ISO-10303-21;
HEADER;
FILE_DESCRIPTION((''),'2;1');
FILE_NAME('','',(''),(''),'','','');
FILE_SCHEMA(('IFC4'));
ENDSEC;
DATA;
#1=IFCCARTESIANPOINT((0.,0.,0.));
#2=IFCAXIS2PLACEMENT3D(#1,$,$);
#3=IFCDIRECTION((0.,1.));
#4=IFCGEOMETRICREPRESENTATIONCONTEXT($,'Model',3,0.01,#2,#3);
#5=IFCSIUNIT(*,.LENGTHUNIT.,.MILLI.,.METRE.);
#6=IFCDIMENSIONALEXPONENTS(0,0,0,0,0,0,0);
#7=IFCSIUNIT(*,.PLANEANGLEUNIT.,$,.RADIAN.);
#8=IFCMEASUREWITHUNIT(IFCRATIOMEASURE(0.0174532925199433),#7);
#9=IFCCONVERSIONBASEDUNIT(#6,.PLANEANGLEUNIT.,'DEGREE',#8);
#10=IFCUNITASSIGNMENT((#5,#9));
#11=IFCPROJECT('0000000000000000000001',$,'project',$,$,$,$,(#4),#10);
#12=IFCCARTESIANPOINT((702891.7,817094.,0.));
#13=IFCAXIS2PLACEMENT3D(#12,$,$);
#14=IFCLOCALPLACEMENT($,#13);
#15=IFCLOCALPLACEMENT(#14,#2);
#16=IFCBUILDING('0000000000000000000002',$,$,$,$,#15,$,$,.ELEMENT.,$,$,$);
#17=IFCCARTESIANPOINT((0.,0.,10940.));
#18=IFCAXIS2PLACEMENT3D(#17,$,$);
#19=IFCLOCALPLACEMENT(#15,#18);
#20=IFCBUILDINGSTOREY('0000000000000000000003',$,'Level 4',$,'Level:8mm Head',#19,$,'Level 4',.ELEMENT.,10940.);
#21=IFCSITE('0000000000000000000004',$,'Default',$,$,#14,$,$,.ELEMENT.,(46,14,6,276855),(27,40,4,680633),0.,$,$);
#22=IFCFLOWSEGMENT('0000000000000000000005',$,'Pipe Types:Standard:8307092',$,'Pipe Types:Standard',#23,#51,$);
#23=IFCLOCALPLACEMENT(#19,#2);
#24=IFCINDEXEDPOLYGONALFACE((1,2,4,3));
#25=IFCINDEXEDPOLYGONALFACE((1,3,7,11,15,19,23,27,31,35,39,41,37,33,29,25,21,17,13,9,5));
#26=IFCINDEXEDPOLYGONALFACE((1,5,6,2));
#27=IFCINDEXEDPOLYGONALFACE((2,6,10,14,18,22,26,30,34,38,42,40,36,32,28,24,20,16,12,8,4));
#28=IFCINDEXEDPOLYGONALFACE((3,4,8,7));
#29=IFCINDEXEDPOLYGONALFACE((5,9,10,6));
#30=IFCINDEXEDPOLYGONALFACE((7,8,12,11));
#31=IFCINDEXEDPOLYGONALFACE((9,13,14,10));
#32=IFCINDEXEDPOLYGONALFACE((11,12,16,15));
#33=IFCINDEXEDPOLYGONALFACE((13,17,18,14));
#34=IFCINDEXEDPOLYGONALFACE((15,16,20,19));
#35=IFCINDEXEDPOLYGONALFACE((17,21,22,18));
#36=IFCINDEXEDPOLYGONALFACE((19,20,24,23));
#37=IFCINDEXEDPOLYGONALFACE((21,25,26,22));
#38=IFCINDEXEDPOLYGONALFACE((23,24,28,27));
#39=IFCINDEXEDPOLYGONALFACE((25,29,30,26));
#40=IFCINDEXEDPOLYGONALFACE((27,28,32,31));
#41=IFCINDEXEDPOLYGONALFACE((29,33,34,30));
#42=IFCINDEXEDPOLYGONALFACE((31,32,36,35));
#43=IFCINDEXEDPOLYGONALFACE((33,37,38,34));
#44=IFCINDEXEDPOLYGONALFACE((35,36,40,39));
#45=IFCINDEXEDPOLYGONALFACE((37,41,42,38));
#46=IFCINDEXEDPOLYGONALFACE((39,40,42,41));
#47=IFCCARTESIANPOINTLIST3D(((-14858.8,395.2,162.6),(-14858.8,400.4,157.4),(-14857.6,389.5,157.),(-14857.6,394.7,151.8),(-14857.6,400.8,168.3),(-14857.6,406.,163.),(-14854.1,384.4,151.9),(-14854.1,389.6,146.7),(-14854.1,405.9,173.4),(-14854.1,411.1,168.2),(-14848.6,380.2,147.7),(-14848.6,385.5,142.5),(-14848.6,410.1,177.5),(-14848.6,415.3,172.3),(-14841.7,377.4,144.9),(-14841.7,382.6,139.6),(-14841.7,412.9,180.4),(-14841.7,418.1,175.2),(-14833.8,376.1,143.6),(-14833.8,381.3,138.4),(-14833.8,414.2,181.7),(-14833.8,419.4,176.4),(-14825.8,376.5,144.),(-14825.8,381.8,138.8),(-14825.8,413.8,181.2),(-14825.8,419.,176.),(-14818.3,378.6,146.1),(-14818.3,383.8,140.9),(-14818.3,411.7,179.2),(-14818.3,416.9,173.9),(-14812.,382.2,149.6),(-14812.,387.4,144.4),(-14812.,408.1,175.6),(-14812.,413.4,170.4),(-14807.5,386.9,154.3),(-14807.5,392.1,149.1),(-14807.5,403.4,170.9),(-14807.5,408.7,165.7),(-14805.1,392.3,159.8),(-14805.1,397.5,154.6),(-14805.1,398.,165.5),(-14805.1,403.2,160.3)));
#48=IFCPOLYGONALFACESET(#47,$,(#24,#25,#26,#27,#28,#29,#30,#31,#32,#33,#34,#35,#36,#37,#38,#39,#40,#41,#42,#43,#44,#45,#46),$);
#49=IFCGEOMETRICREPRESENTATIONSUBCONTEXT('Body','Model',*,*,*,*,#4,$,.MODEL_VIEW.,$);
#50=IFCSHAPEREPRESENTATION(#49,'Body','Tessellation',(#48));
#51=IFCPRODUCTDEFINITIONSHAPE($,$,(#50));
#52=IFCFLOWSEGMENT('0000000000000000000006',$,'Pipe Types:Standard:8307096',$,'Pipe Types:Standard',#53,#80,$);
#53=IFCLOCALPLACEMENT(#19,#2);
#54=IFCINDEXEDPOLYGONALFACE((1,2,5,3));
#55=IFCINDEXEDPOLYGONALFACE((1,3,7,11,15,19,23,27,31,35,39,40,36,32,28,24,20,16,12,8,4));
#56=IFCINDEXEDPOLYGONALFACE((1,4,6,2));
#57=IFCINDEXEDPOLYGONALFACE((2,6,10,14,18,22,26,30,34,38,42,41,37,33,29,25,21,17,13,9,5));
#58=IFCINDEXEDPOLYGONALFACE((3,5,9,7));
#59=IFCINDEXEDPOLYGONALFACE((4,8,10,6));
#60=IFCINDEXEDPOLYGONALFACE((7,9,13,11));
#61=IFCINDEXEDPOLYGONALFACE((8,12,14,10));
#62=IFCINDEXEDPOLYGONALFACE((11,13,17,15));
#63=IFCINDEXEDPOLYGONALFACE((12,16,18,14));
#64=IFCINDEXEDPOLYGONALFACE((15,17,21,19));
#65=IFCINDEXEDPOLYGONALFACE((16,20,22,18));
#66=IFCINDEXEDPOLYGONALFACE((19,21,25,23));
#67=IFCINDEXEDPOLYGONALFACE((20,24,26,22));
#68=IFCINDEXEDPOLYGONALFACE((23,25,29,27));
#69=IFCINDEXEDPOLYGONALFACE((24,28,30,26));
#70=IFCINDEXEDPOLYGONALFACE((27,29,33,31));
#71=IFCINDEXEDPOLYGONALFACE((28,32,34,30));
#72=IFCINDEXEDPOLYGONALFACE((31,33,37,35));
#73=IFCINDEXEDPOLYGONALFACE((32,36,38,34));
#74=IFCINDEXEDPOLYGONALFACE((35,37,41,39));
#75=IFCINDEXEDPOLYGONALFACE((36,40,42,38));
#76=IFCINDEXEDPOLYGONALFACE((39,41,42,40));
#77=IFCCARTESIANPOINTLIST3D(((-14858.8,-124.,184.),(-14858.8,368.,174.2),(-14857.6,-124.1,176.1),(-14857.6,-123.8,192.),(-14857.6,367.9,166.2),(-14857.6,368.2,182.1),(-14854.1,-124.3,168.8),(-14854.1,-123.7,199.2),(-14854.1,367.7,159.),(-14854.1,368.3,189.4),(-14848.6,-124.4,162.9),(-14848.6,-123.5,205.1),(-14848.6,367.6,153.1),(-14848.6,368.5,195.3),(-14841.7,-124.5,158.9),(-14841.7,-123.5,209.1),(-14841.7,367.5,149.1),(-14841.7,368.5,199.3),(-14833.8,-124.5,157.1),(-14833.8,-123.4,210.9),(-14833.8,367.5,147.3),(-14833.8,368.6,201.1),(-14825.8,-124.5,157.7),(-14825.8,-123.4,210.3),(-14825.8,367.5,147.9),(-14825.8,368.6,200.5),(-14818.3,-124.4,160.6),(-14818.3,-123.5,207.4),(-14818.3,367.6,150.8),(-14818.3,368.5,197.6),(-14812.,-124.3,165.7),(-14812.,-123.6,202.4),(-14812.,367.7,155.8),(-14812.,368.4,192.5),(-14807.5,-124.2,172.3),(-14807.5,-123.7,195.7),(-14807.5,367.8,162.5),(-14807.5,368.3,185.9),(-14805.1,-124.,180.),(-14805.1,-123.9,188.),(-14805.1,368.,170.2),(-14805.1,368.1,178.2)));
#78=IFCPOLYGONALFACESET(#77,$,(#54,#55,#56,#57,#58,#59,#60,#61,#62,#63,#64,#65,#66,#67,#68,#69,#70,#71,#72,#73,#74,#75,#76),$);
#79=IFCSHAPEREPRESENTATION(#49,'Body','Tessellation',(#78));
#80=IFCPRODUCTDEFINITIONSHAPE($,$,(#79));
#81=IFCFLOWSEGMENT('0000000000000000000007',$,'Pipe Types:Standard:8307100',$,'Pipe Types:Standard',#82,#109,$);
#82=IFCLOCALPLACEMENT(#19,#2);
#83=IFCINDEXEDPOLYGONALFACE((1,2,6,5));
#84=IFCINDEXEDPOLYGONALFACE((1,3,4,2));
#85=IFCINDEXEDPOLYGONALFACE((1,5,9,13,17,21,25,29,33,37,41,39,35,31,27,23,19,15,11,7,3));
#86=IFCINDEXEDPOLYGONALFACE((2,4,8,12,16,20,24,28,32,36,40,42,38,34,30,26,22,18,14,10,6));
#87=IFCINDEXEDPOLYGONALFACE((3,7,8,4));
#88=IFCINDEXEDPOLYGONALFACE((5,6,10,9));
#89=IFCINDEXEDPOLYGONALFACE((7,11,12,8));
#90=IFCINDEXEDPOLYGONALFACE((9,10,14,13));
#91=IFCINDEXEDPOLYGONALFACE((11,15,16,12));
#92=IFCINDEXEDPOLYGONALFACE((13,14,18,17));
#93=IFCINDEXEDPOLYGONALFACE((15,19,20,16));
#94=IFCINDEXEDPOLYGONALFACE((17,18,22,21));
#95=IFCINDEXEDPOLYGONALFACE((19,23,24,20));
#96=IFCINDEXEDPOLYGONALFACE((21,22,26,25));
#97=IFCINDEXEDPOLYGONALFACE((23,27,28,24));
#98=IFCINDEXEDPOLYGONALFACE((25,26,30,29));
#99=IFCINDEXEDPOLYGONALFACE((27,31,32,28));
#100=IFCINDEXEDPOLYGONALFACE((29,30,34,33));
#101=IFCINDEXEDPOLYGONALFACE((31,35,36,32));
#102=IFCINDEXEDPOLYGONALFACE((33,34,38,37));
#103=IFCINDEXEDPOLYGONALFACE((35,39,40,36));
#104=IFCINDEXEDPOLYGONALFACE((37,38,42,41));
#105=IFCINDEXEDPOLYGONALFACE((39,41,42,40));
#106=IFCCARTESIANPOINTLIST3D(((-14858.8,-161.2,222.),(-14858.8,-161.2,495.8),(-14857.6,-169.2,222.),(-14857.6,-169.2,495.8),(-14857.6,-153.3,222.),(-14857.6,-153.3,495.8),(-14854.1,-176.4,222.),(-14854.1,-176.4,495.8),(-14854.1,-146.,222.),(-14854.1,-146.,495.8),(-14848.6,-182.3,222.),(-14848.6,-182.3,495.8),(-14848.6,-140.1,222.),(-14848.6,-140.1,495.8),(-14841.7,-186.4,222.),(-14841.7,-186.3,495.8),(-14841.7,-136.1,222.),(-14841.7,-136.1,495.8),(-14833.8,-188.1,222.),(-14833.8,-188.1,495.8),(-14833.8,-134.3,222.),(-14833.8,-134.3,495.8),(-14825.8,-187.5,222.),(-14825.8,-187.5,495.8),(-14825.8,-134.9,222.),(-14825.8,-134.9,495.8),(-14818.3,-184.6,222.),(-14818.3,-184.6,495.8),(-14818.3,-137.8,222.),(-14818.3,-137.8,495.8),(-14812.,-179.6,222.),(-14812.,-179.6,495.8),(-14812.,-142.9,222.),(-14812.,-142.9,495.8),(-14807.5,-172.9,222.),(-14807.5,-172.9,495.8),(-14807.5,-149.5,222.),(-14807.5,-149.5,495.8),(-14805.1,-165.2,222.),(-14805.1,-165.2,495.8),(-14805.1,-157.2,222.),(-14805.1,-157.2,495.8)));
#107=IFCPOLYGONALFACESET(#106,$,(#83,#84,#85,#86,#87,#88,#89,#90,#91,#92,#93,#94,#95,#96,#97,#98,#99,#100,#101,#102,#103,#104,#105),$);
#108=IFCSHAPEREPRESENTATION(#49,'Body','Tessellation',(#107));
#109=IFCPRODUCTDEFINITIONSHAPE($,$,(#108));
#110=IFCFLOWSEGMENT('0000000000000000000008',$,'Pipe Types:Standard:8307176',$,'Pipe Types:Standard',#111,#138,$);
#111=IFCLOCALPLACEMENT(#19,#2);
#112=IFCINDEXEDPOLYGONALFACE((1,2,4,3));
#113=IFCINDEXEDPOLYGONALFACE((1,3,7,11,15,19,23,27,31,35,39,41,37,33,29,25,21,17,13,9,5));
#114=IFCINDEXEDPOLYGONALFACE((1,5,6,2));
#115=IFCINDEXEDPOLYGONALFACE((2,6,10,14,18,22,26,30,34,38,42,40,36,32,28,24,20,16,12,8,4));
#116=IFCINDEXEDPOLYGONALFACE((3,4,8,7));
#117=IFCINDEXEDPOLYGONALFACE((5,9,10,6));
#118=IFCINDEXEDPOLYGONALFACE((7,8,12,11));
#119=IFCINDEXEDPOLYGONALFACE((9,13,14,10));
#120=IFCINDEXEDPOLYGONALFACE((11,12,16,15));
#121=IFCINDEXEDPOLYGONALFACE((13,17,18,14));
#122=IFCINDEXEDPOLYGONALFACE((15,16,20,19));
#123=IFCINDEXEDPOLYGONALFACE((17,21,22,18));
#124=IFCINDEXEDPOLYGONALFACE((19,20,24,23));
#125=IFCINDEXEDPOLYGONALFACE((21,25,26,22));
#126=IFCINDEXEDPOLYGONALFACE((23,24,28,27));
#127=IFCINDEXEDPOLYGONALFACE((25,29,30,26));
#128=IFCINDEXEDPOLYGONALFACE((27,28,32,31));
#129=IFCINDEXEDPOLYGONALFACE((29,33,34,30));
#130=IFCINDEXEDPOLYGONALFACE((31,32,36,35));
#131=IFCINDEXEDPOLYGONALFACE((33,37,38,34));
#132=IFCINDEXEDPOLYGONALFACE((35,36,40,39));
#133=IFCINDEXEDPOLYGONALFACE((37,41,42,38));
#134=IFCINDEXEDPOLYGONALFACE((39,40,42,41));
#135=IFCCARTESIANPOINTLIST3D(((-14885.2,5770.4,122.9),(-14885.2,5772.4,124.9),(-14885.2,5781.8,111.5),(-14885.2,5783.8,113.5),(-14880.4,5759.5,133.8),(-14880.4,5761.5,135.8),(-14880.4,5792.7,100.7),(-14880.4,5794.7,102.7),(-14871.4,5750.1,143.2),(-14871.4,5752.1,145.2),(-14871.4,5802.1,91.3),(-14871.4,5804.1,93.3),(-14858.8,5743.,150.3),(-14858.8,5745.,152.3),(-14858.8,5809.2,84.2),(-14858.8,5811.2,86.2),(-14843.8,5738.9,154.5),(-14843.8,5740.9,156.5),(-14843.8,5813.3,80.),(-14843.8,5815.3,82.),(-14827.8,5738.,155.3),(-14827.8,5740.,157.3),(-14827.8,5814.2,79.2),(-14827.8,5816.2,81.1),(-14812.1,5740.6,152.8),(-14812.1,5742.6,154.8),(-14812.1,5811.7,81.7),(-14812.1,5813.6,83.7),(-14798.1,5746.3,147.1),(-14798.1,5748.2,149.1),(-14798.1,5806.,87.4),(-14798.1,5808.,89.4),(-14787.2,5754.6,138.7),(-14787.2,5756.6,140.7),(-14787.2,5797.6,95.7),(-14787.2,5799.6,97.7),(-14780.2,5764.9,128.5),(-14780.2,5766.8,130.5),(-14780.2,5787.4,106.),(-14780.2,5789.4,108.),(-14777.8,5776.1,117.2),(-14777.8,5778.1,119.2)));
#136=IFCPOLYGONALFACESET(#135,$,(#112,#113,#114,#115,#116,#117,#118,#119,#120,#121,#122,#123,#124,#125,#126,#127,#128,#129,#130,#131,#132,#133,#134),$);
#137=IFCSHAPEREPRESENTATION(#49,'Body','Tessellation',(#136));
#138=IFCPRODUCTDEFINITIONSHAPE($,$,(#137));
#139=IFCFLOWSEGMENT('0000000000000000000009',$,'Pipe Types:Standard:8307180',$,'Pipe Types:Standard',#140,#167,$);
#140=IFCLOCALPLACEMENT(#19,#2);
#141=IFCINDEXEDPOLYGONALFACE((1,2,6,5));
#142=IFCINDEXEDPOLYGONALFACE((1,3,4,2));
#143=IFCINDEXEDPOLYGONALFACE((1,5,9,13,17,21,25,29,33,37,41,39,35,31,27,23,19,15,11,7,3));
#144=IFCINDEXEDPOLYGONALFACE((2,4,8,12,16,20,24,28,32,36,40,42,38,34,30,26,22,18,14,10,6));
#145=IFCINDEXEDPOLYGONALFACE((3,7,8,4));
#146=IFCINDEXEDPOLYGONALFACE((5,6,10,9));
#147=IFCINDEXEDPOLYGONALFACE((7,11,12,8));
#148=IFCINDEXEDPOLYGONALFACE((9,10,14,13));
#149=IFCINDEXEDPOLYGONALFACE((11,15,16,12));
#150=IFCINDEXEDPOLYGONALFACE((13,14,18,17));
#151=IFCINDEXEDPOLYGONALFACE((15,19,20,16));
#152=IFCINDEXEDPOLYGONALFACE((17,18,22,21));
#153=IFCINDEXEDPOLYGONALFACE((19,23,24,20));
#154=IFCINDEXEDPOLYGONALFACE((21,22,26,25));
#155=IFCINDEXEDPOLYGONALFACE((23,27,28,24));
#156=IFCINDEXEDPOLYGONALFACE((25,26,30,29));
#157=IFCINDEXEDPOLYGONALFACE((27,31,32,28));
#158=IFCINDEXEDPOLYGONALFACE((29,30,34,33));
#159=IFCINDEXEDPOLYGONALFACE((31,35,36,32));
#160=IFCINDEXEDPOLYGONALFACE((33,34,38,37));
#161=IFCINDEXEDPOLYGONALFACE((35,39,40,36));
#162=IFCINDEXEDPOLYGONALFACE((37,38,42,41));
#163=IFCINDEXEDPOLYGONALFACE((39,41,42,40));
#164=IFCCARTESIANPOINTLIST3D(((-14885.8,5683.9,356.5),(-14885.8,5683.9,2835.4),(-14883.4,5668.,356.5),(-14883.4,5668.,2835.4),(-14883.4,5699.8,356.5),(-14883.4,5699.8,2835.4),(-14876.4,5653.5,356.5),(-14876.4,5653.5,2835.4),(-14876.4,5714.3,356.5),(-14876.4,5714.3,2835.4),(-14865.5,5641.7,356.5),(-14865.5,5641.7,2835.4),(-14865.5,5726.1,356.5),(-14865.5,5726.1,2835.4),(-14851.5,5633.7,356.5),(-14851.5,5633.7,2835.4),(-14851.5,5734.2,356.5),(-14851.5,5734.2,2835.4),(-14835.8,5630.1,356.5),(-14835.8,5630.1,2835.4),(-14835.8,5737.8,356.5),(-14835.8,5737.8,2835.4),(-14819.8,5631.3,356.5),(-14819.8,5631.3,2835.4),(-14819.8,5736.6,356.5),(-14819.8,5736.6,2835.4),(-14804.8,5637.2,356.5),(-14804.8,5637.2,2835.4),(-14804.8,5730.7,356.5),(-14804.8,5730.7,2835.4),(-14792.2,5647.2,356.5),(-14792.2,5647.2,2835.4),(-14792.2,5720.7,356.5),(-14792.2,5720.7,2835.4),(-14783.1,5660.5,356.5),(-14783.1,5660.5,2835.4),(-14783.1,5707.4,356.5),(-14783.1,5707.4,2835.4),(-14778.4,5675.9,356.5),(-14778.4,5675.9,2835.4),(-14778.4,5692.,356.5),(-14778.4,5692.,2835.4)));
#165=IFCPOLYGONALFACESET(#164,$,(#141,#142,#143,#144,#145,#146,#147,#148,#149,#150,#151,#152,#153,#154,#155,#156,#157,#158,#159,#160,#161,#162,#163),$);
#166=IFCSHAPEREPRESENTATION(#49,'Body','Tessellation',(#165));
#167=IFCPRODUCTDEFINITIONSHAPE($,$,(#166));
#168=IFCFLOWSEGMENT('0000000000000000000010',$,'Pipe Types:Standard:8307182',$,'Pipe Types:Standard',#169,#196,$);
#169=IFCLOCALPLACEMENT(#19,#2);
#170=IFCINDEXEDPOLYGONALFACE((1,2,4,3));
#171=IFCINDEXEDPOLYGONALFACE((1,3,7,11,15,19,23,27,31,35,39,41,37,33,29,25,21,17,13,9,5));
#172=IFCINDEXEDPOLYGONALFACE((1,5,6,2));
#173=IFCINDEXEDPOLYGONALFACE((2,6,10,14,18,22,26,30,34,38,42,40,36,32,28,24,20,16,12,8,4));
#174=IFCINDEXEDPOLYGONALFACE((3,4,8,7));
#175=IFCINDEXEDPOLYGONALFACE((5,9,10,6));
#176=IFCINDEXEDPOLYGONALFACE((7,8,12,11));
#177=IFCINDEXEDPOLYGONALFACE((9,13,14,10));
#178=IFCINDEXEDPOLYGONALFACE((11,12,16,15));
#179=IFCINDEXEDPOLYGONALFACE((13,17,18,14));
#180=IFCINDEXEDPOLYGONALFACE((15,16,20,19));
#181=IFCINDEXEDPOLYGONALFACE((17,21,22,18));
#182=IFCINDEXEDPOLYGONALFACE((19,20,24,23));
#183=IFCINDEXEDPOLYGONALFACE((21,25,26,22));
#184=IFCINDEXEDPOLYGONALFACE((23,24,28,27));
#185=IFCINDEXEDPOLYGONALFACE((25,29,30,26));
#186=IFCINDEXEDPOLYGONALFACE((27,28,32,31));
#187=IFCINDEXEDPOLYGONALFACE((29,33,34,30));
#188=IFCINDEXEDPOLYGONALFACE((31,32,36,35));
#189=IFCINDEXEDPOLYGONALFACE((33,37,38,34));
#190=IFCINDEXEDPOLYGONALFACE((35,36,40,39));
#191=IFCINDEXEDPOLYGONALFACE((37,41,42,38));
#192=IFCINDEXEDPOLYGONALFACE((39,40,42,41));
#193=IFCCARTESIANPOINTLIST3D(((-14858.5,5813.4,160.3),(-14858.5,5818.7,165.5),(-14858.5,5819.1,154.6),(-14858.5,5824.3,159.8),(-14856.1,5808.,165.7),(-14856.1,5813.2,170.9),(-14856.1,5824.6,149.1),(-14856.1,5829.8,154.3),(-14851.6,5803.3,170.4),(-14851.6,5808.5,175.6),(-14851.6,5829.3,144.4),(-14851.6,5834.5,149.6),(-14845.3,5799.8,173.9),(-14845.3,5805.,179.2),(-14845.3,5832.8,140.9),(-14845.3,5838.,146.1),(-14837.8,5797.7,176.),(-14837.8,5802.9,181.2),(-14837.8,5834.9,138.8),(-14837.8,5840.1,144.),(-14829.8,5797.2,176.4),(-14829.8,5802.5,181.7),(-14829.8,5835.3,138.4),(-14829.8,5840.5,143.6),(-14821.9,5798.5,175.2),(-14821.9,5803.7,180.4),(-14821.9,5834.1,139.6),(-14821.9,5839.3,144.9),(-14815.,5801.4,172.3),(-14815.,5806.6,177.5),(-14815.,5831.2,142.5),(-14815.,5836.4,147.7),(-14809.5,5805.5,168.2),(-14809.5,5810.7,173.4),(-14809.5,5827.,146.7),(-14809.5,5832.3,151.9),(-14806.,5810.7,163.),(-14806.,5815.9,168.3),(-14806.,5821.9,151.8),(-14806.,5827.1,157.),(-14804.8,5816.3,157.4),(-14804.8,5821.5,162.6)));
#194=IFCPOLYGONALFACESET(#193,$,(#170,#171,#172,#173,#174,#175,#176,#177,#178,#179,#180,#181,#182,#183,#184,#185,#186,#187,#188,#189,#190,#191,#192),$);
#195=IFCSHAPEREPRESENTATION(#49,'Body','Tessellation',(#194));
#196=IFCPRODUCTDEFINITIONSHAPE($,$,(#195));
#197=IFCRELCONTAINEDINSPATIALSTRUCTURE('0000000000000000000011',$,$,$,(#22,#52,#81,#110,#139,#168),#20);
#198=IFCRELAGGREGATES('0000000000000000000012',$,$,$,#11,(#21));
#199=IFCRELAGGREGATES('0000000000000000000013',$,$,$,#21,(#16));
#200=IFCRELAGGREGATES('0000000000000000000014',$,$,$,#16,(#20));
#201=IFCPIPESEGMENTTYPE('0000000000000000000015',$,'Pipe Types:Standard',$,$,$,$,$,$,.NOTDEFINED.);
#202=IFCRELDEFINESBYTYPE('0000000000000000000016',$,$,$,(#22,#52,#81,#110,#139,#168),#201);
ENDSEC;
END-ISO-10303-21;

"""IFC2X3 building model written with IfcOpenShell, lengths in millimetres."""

from ifc_helpers import new_model, entity, si_unit, converted_unit, direction, frame, frame_2d, origin, origin_2d_with_axis, place, context, subcontext, project, spatial, circle, extrude, type_object, element, save


model = new_model("IFC2X3")

# Units and contexts
model_context = context("Model", 3, precision=0.01, world=origin(), true_north=direction((0.0, 1.0)))
body_context = subcontext(model_context, "Body", "Model", "MODEL_VIEW")
ifc_project = project(units=[si_unit("LENGTHUNIT", "METRE", prefix="MILLI"), converted_unit("PLANEANGLEUNIT", "DEGREE", entity("IfcRatioMeasure", 0.0174532925199433), si_unit("PLANEANGLEUNIT", "RADIAN"), dimensions=[0, 0, 0, 0, 0, 0, 0])], contexts=[model_context])

# Site, building, storey
site_placement = place(None, frame((702891.7, 817094.0, 0.0)))
site = spatial("IfcSite", under=ifc_project, at=site_placement, Name="Default", CompositionType="ELEMENT", RefLatitude=(46, 14, 6, 276855), RefLongitude=(27, 40, 4, 680633), RefElevation=0.0)
building_placement = place(site_placement, origin())
building = spatial("IfcBuilding", under=site, at=building_placement, CompositionType="ELEMENT")
storey_placement = place(building_placement, frame((0.0, 0.0, 10940.0)))
storey = spatial("IfcBuildingStorey", under=building, at=storey_placement, Name="Level 4", ObjectType="Level:8mm Head", LongName="Level 4", CompositionType="ELEMENT", Elevation=10940.0)

# Flow segments
pipe_segment_type = type_object("IfcPipeSegmentType", Name="Pipe Types:Standard", PredefinedType="NOTDEFINED")
flow_segment_1_placement = place(storey_placement, origin())
element("IfcFlowSegment", 1, at=flow_segment_1_placement, inside=storey, type_object=pipe_segment_type, Name="Pipe Types:Standard:8307092", ObjectType="Pipe Types:Standard", context=body_context, shape_type="SweptSolid", body=[
    extrude(circle(Radius=27.0, at=origin_2d_with_axis()), frame((-14831.8, 400.4, 157.4), z_axis=(0.0, -0.707107, 0.707107), x_axis=(-1.0, 0.0, 0.0)), (0.0, 0.0, 1.0), 7.4),
])
flow_segment_2_placement = place(storey_placement, origin())
element("IfcFlowSegment", 2, at=flow_segment_2_placement, inside=storey, type_object=pipe_segment_type, Name="Pipe Types:Standard:8307096", ObjectType="Pipe Types:Standard", context=body_context, shape_type="SweptSolid", body=[
    extrude(circle(Radius=27.0, at=origin_2d_with_axis()), frame((-14831.8, 368.0, 174.2), z_axis=(0.0, -0.9998, 0.019996), x_axis=(-1.0, 0.0, 0.0)), (0.0, 0.0, 1.0), 492.1),
])
flow_segment_3_placement = place(storey_placement, origin())
element("IfcFlowSegment", 3, at=flow_segment_3_placement, inside=storey, type_object=pipe_segment_type, Name="Pipe Types:Standard:8307100", ObjectType="Pipe Types:Standard", context=body_context, shape_type="SweptSolid", body=[
    extrude(circle(Radius=27.0, at=frame_2d((0.0, 0.0), x_axis=(1.0, 0.0))), frame((-14831.8, -161.2, 222.0), z_axis=(0.0, 0.000001, 1.0), x_axis=(-1.0, 0.0, 0.0)), (0.0, 0.0, 1.0), 273.7),
])
flow_segment_4_placement = place(storey_placement, origin())
element("IfcFlowSegment", 4, at=flow_segment_4_placement, inside=storey, type_object=pipe_segment_type, Name="Pipe Types:Standard:8307176", ObjectType="Pipe Types:Standard", context=body_context, shape_type="SweptSolid", body=[
    extrude(circle(Radius=54.0, at=frame_2d((0.0, 0.0), x_axis=(1.0, 0.0))), frame((-14831.8, 5776.1, 117.2), z_axis=(0.0, 0.707107, 0.707107), x_axis=(1.0, 0.0, 0.0)), (0.0, 0.0, 1.0), 2.8),
])
flow_segment_5_placement = place(storey_placement, origin())
element("IfcFlowSegment", 5, at=flow_segment_5_placement, inside=storey, type_object=pipe_segment_type, Name="Pipe Types:Standard:8307180", ObjectType="Pipe Types:Standard", context=body_context, shape_type="SweptSolid", body=[
    extrude(circle(Radius=54.0, at=origin_2d_with_axis()), frame((-14831.8, 5683.9, 356.5), z_axis=(0.0, 0.0, 1.0), x_axis=(-1.0, 0.0, 0.0)), (0.0, 0.0, 1.0), 2479.0),
])
flow_segment_6_placement = place(storey_placement, origin())
element("IfcFlowSegment", 6, at=flow_segment_6_placement, inside=storey, type_object=pipe_segment_type, Name="Pipe Types:Standard:8307182", ObjectType="Pipe Types:Standard", context=body_context, shape_type="SweptSolid", body=[
    extrude(circle(Radius=27.0, at=frame_2d((0.0, 0.0), x_axis=(1.0, 0.0))), frame((-14831.8, 5816.3, 157.4), z_axis=(0.0, 0.707107, 0.707107), x_axis=(1.0, 0.0, 0.0)), (0.0, 0.0, 1.0), 7.4),
])

save(model, "model.ifc")
